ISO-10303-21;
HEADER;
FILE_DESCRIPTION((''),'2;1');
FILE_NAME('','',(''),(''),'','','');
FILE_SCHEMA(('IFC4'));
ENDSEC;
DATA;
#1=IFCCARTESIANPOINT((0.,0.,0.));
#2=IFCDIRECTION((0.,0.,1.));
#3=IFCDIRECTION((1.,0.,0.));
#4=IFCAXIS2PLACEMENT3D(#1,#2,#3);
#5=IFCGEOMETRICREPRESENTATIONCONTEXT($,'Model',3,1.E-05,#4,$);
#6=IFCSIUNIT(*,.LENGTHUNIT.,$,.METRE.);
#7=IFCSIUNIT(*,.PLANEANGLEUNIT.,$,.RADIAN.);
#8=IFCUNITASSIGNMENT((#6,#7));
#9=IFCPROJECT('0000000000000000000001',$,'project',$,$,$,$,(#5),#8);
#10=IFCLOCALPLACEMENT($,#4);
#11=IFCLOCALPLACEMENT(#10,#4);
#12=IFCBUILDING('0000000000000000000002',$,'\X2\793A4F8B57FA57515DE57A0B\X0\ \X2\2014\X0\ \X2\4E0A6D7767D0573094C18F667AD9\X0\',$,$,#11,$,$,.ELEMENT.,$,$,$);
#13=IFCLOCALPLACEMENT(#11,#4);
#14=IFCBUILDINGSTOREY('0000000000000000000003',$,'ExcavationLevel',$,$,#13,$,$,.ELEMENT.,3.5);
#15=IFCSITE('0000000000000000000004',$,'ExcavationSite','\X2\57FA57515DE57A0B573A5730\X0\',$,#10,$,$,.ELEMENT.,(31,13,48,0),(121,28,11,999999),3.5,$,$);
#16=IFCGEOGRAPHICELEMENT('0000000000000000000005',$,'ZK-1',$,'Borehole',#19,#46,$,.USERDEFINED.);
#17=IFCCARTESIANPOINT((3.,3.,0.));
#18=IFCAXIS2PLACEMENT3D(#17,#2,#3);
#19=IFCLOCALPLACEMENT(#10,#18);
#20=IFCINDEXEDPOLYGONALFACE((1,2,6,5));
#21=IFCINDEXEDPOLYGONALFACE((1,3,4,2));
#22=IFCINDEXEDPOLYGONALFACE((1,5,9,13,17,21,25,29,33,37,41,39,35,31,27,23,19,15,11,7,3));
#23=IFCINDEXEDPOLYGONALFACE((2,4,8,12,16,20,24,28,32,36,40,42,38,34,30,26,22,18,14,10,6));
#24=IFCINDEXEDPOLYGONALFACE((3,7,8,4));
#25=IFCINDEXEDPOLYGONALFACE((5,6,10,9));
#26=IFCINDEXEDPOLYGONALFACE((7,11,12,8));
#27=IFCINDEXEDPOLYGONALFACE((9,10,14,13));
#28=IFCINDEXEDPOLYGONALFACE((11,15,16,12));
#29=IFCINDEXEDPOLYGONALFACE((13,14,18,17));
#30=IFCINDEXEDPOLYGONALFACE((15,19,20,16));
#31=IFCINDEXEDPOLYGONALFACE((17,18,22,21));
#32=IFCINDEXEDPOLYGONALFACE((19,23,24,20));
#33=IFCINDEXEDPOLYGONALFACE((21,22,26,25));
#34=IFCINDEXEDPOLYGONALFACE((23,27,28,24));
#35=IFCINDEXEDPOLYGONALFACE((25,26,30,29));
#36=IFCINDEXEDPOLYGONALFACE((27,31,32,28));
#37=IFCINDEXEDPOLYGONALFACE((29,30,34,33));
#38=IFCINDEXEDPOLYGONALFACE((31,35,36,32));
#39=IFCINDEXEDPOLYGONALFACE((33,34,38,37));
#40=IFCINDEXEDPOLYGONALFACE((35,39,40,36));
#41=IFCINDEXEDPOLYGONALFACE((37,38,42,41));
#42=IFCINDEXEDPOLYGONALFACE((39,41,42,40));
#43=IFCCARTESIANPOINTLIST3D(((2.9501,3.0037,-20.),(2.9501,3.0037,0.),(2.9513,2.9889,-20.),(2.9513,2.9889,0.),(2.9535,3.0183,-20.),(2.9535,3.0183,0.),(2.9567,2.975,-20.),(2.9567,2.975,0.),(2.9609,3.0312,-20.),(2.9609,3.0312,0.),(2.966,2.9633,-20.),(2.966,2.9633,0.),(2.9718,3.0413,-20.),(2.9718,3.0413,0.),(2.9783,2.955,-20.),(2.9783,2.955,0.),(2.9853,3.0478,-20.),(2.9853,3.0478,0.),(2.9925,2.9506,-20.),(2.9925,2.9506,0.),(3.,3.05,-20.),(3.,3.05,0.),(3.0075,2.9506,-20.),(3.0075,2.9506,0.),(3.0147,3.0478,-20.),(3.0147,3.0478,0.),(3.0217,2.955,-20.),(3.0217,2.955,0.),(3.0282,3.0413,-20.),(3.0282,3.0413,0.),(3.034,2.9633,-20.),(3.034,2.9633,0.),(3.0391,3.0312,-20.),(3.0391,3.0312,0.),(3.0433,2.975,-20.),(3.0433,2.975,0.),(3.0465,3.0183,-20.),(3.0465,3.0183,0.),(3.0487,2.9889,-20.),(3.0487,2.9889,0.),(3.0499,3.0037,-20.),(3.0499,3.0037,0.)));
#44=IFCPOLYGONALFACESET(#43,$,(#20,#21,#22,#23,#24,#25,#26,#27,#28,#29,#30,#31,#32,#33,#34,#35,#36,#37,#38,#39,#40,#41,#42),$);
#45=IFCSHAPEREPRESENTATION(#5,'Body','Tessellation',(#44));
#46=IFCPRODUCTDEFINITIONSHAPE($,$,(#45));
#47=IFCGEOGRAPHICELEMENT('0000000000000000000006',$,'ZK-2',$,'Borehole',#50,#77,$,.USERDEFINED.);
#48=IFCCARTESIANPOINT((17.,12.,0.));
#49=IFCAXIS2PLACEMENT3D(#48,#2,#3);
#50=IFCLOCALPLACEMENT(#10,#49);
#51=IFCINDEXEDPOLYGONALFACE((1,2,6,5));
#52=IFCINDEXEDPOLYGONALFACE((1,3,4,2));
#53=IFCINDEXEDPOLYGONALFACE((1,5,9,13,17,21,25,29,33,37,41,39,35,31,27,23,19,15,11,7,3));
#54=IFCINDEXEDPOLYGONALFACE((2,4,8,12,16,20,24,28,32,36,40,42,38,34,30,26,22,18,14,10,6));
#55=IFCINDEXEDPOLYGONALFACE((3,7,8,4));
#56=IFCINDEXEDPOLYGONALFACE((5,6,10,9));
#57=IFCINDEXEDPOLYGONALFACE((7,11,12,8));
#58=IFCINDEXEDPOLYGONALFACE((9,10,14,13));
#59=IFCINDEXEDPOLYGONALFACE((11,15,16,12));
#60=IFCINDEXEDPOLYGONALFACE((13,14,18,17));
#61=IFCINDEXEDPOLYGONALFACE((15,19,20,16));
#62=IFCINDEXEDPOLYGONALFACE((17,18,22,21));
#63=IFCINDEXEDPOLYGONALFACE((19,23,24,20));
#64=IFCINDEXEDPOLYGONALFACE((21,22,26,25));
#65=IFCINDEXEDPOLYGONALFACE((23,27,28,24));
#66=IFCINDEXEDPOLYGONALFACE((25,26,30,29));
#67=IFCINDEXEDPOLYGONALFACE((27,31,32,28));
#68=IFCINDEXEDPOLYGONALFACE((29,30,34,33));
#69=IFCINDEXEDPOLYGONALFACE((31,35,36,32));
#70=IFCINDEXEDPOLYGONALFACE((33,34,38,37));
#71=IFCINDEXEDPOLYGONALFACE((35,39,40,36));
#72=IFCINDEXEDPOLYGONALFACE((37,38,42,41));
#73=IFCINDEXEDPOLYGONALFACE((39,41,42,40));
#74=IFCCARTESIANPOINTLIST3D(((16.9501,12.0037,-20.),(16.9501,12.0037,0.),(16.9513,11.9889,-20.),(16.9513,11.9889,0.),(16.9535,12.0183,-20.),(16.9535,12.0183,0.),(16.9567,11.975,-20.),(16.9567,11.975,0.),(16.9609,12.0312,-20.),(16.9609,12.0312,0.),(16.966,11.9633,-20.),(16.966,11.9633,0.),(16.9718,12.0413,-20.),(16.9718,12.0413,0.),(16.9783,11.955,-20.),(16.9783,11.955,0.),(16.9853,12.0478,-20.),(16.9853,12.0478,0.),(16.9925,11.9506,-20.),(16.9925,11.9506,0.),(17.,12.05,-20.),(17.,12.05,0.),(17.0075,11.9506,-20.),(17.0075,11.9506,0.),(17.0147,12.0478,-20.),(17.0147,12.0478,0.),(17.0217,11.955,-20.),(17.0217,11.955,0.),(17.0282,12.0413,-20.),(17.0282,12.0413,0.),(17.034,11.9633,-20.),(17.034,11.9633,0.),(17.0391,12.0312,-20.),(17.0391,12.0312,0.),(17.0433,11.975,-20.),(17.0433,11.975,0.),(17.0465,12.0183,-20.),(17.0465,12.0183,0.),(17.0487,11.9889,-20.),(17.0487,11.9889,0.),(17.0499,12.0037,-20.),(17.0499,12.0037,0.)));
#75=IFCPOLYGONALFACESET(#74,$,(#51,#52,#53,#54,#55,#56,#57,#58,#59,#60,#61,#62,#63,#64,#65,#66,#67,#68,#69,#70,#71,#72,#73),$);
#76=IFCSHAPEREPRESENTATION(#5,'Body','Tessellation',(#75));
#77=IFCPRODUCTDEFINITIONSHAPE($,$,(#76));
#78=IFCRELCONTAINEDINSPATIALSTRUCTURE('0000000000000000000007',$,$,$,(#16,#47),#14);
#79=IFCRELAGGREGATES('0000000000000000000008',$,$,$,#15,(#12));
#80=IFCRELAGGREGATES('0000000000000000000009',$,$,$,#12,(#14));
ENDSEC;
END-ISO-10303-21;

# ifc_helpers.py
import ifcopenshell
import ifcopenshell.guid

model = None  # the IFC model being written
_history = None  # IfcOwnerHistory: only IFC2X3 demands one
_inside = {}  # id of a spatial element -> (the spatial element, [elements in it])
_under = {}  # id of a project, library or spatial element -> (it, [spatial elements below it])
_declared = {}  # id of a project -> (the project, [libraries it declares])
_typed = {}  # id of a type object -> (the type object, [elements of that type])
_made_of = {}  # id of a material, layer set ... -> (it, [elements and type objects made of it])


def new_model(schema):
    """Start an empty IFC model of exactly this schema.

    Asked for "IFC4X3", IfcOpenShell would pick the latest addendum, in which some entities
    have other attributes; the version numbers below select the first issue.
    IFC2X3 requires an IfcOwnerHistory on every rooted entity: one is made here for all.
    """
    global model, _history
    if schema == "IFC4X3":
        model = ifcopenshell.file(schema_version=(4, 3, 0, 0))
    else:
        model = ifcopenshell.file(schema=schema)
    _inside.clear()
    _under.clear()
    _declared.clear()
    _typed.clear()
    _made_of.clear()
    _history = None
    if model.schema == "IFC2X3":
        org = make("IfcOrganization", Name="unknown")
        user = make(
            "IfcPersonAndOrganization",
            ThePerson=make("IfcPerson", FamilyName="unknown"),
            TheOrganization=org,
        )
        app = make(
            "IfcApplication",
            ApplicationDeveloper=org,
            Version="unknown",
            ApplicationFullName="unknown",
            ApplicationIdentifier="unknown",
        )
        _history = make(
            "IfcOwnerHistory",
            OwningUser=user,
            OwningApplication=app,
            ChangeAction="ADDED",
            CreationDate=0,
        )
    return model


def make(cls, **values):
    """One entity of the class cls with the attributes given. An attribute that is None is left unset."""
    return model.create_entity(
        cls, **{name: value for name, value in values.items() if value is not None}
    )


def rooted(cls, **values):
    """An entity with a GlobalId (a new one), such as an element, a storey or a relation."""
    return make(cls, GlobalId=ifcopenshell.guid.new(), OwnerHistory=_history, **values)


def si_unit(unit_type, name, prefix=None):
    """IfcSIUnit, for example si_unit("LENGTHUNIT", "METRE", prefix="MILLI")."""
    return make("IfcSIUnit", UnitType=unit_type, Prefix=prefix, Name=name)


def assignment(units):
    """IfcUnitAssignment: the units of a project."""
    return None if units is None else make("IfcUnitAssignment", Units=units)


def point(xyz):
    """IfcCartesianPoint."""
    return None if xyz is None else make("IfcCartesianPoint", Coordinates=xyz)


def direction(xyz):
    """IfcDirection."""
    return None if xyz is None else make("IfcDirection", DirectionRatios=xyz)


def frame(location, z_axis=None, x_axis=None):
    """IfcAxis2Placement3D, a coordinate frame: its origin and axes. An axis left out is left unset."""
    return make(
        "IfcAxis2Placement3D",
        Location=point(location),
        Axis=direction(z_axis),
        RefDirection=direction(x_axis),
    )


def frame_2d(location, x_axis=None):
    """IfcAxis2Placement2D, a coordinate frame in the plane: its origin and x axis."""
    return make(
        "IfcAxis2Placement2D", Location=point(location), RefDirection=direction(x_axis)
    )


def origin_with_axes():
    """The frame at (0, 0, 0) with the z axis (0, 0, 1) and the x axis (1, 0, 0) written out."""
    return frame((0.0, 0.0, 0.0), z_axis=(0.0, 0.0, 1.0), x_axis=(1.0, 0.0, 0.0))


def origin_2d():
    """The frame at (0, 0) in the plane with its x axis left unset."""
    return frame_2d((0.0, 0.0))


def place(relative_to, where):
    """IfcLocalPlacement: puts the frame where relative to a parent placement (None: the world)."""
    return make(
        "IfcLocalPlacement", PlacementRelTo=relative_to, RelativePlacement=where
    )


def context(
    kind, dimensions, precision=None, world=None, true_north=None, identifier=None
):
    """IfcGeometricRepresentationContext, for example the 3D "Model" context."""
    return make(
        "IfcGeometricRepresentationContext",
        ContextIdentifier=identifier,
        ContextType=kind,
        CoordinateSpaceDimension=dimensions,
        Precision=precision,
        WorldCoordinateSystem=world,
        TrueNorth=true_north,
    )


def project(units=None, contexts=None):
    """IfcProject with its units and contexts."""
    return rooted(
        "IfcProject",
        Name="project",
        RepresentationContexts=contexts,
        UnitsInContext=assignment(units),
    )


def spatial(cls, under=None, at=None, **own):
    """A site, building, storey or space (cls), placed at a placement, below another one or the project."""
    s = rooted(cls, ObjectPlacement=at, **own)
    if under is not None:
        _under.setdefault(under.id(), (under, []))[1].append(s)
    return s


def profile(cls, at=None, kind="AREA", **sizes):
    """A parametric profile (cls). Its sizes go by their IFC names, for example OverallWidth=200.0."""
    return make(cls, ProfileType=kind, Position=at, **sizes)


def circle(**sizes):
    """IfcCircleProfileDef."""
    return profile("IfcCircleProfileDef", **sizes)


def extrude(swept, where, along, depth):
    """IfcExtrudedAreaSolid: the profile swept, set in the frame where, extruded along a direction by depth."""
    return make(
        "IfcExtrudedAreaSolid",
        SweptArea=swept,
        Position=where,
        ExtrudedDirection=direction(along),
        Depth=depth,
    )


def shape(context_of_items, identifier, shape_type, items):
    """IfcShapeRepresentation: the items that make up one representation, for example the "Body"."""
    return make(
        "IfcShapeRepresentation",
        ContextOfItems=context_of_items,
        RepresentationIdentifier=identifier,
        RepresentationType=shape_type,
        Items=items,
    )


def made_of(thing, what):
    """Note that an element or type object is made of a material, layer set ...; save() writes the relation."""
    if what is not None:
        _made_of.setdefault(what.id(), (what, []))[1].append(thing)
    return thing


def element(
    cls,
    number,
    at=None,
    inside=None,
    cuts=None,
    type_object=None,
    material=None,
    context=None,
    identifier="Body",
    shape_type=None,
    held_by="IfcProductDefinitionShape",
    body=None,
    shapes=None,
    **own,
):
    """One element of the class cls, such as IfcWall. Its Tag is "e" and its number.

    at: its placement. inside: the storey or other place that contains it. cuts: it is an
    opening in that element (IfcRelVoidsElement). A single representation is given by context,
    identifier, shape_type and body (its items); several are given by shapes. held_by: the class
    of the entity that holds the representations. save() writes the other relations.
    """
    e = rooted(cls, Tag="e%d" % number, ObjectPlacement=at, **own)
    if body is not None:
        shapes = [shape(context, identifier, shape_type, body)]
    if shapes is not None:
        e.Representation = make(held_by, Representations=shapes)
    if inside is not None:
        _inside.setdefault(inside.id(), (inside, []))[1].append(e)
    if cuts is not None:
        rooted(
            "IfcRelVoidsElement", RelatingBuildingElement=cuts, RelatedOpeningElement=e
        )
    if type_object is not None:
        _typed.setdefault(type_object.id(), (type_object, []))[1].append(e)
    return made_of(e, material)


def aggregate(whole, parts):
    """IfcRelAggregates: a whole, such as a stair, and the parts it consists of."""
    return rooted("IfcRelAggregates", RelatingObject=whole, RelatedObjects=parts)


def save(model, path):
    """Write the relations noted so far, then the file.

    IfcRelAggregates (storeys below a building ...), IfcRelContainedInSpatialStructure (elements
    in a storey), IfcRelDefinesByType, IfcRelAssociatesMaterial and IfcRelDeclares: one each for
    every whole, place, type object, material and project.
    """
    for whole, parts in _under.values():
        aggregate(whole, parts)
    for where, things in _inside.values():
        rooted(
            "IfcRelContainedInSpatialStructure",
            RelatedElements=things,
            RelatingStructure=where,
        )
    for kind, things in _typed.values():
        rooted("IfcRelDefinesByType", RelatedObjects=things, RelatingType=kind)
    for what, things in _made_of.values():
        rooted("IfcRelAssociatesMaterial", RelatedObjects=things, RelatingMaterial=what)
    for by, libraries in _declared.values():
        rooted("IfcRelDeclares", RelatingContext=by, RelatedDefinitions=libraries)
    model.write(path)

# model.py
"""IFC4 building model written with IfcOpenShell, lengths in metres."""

from ifc_helpers import new_model, si_unit, frame, origin_with_axes, origin_2d, place, context, project, spatial, circle, extrude, element, save


model = new_model("IFC4")

# Units and contexts
model_context = context("Model", 3, precision=1e-05, world=origin_with_axes())
ifc_project = project(units=[si_unit("LENGTHUNIT", "METRE"), si_unit("PLANEANGLEUNIT", "RADIAN")], contexts=[model_context])

# Site, building, storey
site_placement = place(None, origin_with_axes())
site = spatial("IfcSite", at=site_placement, Name="ExcavationSite", Description="基坑工程场地", CompositionType="ELEMENT", RefLatitude=(31, 13, 48, 0), RefLongitude=(121, 28, 11, 999999), RefElevation=3.5)
building_placement = place(site_placement, origin_with_axes())
building = spatial("IfcBuilding", under=site, at=building_placement, Name="示例基坑工程 — 上海某地铁车站", CompositionType="ELEMENT")
storey_placement = place(building_placement, origin_with_axes())
storey = spatial("IfcBuildingStorey", under=building, at=storey_placement, Name="ExcavationLevel", CompositionType="ELEMENT", Elevation=3.5)

# Geographic elements
geographic_element_1_placement = place(site_placement, frame((3.0, 3.0, 0.0), z_axis=(0.0, 0.0, 1.0), x_axis=(1.0, 0.0, 0.0)))
element("IfcGeographicElement", 1, at=geographic_element_1_placement, inside=storey, Name="ZK-1", ObjectType="Borehole", PredefinedType="USERDEFINED", context=model_context, shape_type="SweptSolid", body=[
    extrude(circle(Radius=0.05, at=origin_2d()), frame((3.0, 3.0, 0.0), z_axis=(0.0, 0.0, -1.0), x_axis=(0.0, 1.0, 0.0)), (0.0, 0.0, 1.0), 20.0),
])
geographic_element_2_placement = place(site_placement, frame((17.0, 12.0, 0.0), z_axis=(0.0, 0.0, 1.0), x_axis=(1.0, 0.0, 0.0)))
element("IfcGeographicElement", 2, at=geographic_element_2_placement, inside=storey, Name="ZK-2", ObjectType="Borehole", PredefinedType="USERDEFINED", context=model_context, shape_type="SweptSolid", body=[
    extrude(circle(Radius=0.05, at=origin_2d()), frame((17.0, 12.0, 0.0), z_axis=(0.0, 0.0, -1.0), x_axis=(0.0, 1.0, 0.0)), (0.0, 0.0, 1.0), 20.0),
])

save(model, "model.ifc")
